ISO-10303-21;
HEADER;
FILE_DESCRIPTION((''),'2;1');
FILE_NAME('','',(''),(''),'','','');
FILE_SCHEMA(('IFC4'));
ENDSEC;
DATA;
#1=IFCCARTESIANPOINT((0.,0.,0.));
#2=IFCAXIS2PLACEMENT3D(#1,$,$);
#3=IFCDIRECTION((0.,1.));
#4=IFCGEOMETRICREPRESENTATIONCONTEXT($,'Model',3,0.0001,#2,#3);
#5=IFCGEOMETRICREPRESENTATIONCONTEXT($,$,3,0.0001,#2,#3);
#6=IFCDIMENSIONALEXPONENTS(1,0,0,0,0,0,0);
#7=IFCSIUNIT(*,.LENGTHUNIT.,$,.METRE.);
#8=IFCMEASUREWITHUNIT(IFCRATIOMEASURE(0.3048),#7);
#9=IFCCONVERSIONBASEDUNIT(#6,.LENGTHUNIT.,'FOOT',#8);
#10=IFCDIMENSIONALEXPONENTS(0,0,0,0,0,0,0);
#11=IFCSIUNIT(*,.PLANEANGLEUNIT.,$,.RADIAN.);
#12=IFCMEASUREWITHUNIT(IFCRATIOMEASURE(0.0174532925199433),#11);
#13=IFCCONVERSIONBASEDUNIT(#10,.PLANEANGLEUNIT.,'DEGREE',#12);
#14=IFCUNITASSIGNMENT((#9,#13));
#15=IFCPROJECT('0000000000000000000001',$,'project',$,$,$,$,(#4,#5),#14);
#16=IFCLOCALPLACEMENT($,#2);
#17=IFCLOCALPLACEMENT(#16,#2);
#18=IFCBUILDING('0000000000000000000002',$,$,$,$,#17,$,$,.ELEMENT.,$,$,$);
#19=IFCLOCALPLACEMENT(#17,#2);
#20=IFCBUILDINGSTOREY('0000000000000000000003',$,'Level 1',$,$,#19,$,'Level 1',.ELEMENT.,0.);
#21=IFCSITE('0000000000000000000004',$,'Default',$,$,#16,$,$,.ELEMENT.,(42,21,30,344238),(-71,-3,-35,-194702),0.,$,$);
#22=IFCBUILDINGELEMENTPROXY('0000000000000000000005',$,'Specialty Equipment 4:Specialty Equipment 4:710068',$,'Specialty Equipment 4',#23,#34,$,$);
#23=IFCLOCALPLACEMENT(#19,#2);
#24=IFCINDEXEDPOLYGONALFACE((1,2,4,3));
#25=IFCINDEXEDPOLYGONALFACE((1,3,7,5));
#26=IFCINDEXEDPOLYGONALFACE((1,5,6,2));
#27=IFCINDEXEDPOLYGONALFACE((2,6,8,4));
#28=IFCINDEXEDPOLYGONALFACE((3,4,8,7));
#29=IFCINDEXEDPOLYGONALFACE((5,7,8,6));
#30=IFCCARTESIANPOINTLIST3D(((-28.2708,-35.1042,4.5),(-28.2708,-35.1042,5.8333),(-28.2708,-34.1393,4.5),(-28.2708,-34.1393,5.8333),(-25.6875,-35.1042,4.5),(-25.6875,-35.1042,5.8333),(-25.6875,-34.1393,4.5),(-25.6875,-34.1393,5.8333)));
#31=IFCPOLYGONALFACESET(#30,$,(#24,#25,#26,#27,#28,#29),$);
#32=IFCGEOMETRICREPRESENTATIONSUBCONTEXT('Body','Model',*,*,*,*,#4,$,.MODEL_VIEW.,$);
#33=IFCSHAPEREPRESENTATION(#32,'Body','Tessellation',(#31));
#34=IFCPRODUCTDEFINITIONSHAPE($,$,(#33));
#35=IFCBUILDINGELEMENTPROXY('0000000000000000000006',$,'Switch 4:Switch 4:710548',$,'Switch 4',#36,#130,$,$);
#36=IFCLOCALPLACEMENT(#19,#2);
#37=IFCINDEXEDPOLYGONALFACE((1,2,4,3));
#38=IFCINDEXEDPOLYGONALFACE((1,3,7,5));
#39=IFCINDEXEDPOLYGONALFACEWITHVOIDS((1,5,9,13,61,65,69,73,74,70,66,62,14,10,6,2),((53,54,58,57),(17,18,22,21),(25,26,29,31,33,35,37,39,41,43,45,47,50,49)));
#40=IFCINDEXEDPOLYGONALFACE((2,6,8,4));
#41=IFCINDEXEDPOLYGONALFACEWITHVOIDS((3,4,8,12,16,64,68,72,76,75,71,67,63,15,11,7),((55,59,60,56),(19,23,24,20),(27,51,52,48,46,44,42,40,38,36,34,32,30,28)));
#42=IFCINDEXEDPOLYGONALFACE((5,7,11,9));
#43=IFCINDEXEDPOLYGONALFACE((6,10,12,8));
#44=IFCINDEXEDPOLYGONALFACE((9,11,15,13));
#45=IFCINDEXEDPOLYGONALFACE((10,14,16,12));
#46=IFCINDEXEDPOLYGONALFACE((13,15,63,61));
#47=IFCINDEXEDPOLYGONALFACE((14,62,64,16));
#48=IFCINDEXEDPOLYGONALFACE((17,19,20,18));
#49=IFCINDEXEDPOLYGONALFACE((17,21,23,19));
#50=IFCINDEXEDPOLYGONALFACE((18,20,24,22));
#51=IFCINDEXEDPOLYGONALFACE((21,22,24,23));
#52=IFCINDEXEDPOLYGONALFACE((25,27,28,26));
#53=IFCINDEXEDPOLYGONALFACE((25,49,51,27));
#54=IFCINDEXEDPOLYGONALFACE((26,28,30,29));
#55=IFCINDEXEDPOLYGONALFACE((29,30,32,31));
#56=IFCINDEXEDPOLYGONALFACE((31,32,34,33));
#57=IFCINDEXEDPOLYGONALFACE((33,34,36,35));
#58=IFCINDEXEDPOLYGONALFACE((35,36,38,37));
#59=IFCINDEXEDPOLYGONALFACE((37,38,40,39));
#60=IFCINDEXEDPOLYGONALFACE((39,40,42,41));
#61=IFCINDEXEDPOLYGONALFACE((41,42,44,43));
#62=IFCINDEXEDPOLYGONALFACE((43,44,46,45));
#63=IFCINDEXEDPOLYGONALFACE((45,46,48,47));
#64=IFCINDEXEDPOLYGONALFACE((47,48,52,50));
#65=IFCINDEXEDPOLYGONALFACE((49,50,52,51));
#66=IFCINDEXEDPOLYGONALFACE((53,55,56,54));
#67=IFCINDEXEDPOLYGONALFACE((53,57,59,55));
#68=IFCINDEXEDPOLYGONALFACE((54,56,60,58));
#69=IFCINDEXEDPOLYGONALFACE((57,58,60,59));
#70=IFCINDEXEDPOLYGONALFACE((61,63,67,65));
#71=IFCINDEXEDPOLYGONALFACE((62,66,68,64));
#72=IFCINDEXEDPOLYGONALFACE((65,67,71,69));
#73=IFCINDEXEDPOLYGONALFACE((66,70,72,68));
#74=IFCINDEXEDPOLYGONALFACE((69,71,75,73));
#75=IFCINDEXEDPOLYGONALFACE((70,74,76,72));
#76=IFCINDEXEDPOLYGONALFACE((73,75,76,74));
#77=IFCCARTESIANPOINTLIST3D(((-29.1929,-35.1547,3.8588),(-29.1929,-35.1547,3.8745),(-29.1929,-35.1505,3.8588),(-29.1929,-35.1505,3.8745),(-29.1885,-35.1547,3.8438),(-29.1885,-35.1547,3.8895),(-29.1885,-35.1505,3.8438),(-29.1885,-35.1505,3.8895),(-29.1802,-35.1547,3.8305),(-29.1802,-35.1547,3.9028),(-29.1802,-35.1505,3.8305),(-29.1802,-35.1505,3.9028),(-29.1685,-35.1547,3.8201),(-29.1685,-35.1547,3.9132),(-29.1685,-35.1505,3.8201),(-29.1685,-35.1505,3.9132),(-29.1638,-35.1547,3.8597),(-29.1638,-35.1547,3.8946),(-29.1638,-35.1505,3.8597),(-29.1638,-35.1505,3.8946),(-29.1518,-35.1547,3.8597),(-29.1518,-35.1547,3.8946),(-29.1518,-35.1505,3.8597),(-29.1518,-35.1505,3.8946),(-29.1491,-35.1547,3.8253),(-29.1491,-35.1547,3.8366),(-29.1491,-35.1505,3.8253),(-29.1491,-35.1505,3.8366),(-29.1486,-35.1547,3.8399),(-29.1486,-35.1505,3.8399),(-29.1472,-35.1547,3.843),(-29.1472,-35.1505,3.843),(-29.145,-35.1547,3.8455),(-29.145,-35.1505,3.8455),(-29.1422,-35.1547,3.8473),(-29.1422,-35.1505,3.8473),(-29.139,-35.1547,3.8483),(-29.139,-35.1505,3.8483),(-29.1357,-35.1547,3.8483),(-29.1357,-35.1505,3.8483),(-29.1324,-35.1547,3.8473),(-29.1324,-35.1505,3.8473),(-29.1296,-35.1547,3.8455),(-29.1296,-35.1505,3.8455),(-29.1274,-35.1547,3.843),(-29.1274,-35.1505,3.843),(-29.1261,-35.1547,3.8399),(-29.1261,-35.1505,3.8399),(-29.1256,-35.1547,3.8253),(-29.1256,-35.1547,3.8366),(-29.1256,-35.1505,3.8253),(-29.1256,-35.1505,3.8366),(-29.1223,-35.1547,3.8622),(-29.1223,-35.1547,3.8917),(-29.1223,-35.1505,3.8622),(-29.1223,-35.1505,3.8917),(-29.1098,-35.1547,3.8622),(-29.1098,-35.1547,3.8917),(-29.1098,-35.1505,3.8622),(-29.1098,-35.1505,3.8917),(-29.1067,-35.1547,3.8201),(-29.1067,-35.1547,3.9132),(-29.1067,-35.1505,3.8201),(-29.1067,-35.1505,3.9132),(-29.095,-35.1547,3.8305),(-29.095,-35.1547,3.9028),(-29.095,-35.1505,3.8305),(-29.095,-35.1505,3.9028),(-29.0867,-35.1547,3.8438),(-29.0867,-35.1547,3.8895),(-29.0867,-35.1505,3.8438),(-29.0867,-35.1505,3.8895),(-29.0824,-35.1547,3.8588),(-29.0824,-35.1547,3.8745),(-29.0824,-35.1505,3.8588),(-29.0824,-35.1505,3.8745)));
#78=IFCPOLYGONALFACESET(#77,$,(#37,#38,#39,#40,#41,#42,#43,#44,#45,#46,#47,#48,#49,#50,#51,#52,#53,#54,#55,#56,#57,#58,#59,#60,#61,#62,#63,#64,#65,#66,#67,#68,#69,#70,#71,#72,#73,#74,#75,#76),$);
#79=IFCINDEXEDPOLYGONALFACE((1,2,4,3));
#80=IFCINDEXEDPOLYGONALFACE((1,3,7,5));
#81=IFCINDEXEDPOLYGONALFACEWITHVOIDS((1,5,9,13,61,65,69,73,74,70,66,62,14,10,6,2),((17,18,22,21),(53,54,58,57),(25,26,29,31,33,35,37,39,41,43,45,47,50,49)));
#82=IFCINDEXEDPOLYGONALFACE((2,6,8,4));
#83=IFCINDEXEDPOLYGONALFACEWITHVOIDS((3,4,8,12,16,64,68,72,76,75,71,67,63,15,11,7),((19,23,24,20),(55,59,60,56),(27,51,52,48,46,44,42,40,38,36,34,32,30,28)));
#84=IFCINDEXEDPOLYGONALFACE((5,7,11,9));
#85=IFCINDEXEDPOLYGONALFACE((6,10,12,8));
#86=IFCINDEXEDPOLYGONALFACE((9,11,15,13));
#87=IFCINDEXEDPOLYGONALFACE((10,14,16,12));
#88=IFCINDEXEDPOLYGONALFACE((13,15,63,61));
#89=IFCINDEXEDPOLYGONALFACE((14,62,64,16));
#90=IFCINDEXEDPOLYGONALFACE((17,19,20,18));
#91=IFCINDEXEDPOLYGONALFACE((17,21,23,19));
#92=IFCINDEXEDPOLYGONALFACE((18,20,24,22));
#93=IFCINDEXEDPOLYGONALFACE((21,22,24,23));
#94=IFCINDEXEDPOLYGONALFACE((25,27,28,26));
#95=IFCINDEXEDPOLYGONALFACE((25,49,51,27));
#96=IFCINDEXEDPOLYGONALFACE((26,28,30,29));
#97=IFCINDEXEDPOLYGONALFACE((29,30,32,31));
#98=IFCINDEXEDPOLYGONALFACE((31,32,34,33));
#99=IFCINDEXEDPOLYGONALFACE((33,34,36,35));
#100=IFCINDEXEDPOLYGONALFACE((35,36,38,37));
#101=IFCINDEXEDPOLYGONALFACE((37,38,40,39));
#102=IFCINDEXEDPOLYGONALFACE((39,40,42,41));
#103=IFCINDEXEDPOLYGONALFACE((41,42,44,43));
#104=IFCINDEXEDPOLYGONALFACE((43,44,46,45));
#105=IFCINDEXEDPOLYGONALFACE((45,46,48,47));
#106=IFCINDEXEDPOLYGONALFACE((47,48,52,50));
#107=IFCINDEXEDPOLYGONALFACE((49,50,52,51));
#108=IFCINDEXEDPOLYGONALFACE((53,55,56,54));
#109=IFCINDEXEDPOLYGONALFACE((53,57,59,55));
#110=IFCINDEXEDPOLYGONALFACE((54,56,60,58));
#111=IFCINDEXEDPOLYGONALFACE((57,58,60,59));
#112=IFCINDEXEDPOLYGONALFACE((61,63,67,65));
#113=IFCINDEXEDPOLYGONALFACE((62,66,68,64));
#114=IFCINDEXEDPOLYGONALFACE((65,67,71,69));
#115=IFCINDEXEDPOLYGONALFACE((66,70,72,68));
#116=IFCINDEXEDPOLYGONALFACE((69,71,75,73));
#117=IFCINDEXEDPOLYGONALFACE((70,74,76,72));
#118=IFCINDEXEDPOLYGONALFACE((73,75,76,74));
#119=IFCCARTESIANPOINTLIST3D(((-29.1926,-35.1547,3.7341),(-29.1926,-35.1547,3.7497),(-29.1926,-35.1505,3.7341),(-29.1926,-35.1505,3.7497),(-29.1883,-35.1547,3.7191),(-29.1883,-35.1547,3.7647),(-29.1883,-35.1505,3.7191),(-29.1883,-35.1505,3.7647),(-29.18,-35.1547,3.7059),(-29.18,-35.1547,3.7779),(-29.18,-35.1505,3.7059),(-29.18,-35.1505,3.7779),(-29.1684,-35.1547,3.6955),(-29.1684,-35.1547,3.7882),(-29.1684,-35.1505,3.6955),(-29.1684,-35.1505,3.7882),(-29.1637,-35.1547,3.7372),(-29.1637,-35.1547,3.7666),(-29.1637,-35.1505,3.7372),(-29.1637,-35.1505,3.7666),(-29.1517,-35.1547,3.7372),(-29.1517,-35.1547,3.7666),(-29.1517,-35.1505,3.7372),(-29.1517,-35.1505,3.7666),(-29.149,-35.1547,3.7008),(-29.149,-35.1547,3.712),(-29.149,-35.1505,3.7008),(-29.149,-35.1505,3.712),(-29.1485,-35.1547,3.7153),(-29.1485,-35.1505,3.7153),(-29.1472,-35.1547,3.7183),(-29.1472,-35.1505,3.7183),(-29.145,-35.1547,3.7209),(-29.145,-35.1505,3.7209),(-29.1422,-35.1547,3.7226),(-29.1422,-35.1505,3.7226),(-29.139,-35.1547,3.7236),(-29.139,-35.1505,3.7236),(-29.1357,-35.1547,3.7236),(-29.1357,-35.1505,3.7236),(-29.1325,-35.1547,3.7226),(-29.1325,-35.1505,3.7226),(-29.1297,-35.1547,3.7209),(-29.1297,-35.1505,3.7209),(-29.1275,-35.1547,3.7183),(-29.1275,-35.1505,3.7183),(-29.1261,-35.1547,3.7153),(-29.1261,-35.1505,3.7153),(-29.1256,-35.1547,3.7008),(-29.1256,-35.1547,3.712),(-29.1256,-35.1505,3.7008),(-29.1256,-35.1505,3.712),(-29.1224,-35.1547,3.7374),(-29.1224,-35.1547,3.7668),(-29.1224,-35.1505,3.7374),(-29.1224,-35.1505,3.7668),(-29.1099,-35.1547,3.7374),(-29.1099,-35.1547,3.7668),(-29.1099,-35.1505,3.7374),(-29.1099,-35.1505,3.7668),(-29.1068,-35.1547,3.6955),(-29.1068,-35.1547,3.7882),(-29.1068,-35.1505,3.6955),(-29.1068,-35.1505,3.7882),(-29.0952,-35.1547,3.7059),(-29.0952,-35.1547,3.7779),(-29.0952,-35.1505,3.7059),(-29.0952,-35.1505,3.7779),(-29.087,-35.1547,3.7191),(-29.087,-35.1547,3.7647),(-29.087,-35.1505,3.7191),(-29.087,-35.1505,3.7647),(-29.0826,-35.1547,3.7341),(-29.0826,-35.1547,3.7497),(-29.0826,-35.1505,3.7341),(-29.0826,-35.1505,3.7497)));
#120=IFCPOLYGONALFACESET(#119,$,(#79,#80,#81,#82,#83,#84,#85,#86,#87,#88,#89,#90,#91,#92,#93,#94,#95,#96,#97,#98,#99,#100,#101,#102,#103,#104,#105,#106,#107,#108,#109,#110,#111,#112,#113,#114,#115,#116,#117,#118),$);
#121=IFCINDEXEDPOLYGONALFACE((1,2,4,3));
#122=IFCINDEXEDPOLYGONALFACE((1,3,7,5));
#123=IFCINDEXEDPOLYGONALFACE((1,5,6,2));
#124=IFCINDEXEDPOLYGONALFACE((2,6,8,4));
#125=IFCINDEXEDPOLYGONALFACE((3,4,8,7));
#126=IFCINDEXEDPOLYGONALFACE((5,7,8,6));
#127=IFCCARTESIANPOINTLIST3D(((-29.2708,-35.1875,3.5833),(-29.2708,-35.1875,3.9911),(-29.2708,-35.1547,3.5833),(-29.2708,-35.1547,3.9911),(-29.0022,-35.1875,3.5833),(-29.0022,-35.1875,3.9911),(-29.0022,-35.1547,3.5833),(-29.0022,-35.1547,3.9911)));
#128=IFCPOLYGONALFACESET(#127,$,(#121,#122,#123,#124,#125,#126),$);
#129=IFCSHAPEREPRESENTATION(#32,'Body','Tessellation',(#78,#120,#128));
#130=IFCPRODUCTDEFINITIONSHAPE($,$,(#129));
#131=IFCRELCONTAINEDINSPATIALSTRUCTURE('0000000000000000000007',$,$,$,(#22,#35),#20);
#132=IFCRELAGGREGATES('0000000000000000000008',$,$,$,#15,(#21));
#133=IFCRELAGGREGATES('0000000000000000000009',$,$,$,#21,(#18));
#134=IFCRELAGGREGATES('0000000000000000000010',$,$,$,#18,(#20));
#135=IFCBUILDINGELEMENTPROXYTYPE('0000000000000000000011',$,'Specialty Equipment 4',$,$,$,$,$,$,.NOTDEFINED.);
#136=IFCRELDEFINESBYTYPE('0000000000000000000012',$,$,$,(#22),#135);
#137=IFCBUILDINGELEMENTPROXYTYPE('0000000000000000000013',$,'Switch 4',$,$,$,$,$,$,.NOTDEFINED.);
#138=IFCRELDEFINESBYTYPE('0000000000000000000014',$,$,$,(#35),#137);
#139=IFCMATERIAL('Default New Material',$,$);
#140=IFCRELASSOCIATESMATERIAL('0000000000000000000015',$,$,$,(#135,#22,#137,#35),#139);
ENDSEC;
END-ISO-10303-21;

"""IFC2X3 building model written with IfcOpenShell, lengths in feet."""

from ifc_helpers import new_model, entity, si_unit, converted_unit, direction, frame, frame_2d, origin, origin_2d_with_axis, place, context, subcontext, project, spatial, polyline, circle_curve, parameter, trimmed, segment, composite_curve, rectangle, outline, extrude, source, transform, mapped, material, type_object, type_shapes, element, save


model = new_model("IFC2X3")

# Units and contexts
model_context = context("Model", 3, precision=0.0001, world=origin(), true_north=direction((0.0, 1.0)))
context_of_model = context(None, 3, precision=0.0001, world=origin(), true_north=direction((0.0, 1.0)))
body_context = subcontext(model_context, "Body", "Model", "MODEL_VIEW")
ifc_project = project(units=[converted_unit("LENGTHUNIT", "FOOT", entity("IfcRatioMeasure", 0.3048), si_unit("LENGTHUNIT", "METRE"), dimensions=[1, 0, 0, 0, 0, 0, 0]), converted_unit("PLANEANGLEUNIT", "DEGREE", entity("IfcRatioMeasure", 0.0174532925199433), si_unit("PLANEANGLEUNIT", "RADIAN"), dimensions=[0, 0, 0, 0, 0, 0, 0])], contexts=[model_context, context_of_model])

# Site, building, storey
site_placement = place(None, origin())
site = spatial("IfcSite", under=ifc_project, at=site_placement, Name="Default", CompositionType="ELEMENT", RefLatitude=(42, 21, 30, 344238), RefLongitude=(-71, -3, -35, -194702), RefElevation=0.0)
building_placement = place(site_placement, origin())
building = spatial("IfcBuilding", under=site, at=building_placement, CompositionType="ELEMENT")
storey_placement = place(building_placement, origin())
storey = spatial("IfcBuildingStorey", under=building, at=storey_placement, Name="Level 1", LongName="Level 1", CompositionType="ELEMENT", Elevation=0.0)

# Shared definitions
ifc_material = material(Name="Default New Material")

# Building element proxies
building_element_proxy_type_1 = type_object("IfcBuildingElementProxyType", Name="Specialty Equipment 4", PredefinedType="NOTDEFINED", material=ifc_material)
shared_shape_1 = source(origin(), body_context, "Body", "SweptSolid", [
    extrude(rectangle(XDim=0.9649, YDim=2.5833, at=frame_2d((0.0, 0.0), x_axis=(1.0, 0.0))), frame((1.2917, 0.4824, 0.0), z_axis=(0.0, 0.0, 1.0), x_axis=(0.0, -1.0, 0.0)), (0.0, 0.0, 1.0), 1.3333),
])
type_shapes(building_element_proxy_type_1, [shared_shape_1])
proxy_1_placement = place(storey_placement, frame((-28.2708, -35.1042, 4.5)))
element("IfcBuildingElementProxy", 1, at=proxy_1_placement, inside=storey, type_object=building_element_proxy_type_1, material=ifc_material, Name="Specialty Equipment 4:Specialty Equipment 4:710068", ObjectType="Specialty Equipment 4", context=body_context, shape_type="MappedRepresentation", body=[
    mapped(shared_shape_1, transform((0.0, 0.0, 0.0), scale=1.0)),
])
building_element_proxy_type_2 = type_object("IfcBuildingElementProxyType", Name="Switch 4", PredefinedType="NOTDEFINED", material=ifc_material)
shared_shape_2 = source(origin(), body_context, "Body", "SweptSolid", [
    extrude(outline(composite_curve([segment(polyline([(-0.0309, -0.0466), (0.0309, -0.0466)]), True, "CONTINUOUS"), segment(trimmed(circle_curve(frame_2d((-0.0003, 0.0), x_axis=(-1.0, 0.0)), 0.0561), [parameter(123.794741)], [parameter(236.205259)], True, "PARAMETER"), True, "CONTINUOUS"), segment(polyline([(0.0309, 0.0466), (-0.0309, 0.0466)]), True, "CONTINUOUS"), segment(trimmed(circle_curve(frame_2d((0.0003, 0.0), x_axis=(1.0, 0.0)), 0.0561), [parameter(123.794741)], [parameter(236.205259)], True, "PARAMETER"), True, "CONTINUOUS")], self_intersect=False), holes=[polyline([(0.0142, 0.0279), (0.0262, 0.0279), (0.0262, -0.0069), (0.0142, -0.0069), (0.0142, 0.0279)]), polyline([(-0.0153, 0.025), (-0.0153, -0.0045), (-0.0278, -0.0045), (-0.0278, 0.025), (-0.0153, 0.025)]), composite_curve([segment(polyline([(-0.012, -0.0413), (-0.012, -0.03)]), True, "CONTINUOUS"), segment(trimmed(circle_curve(frame_2d((-0.0003, -0.03), x_axis=(-1.0, 0.0)), 0.0117), [parameter(180.0)], [parameter(0.0)], True, "PARAMETER"), False, "CONTINUOUS"), segment(polyline([(0.0115, -0.03), (0.0115, -0.0413)]), True, "CONTINUOUS"), segment(polyline([(0.0115, -0.0413), (-0.012, -0.0413)]), True, "CONTINUOUS")], self_intersect=False)]), frame((-0.0011, 0.0328, 0.2833), z_axis=(0.0, 1.0, 0.0), x_axis=(-1.0, 0.0, 0.0)), (0.0, 0.0, 1.0), 0.0042),
    extrude(outline(composite_curve([segment(polyline([(-0.0308, -0.0464), (0.0308, -0.0464)]), True, "CONTINUOUS"), segment(trimmed(circle_curve(frame_2d((-0.0003, 0.0), x_axis=(-1.0, 0.0)), 0.0558), [parameter(123.794741)], [parameter(236.205259)], True, "PARAMETER"), True, "CONTINUOUS"), segment(polyline([(0.0308, 0.0464), (-0.0308, 0.0464)]), True, "CONTINUOUS"), segment(trimmed(circle_curve(frame_2d((0.0003, 0.0), x_axis=(1.0, 0.0)), 0.0558), [parameter(123.794741)], [parameter(236.205259)], True, "PARAMETER"), True, "CONTINUOUS")], self_intersect=False), holes=[polyline([(0.0141, 0.0247), (0.026, 0.0247), (0.026, -0.0047), (0.0141, -0.0047), (0.0141, 0.0247)]), polyline([(-0.0152, 0.0249), (-0.0152, -0.0045), (-0.0277, -0.0045), (-0.0277, 0.0249), (-0.0152, 0.0249)]), composite_curve([segment(polyline([(-0.012, -0.0411), (-0.012, -0.0299)]), True, "CONTINUOUS"), segment(trimmed(circle_curve(frame_2d((-0.0003, -0.0299), x_axis=(-1.0, 0.0)), 0.0117), [parameter(180.0)], [parameter(0.0)], True, "PARAMETER"), False, "CONTINUOUS"), segment(polyline([(0.0114, -0.0299), (0.0114, -0.0411)]), True, "CONTINUOUS"), segment(polyline([(0.0114, -0.0411), (-0.012, -0.0411)]), True, "CONTINUOUS")], self_intersect=False)]), frame((-0.0011, 0.0328, 0.1586), z_axis=(0.0, 1.0, 0.0), x_axis=(-1.0, 0.0, 0.0)), (0.0, 0.0, 1.0), 0.0042),
    extrude(rectangle(XDim=0.0328, YDim=0.2687, at=origin_2d_with_axis()), frame((0.0, 0.0164, 0.0), z_axis=(0.0, 0.0, 1.0), x_axis=(0.0, -1.0, 0.0)), (0.0, 0.0, 1.0), 0.4078),
])
type_shapes(building_element_proxy_type_2, [shared_shape_2])
for number, where, name in (
    (2, (-29.1365, -35.1875, 3.5833), "Switch 4:Switch 4:710548"),
):
    element("IfcBuildingElementProxy", number, at=place(storey_placement, frame(where)), inside=storey, type_object=building_element_proxy_type_2, material=ifc_material, Name=name, ObjectType="Switch 4", context=body_context, shape_type="MappedRepresentation", body=[
        mapped(shared_shape_2, transform((0.0, 0.0, 0.0), scale=1.0)),
    ])

save(model, "model.ifc")
